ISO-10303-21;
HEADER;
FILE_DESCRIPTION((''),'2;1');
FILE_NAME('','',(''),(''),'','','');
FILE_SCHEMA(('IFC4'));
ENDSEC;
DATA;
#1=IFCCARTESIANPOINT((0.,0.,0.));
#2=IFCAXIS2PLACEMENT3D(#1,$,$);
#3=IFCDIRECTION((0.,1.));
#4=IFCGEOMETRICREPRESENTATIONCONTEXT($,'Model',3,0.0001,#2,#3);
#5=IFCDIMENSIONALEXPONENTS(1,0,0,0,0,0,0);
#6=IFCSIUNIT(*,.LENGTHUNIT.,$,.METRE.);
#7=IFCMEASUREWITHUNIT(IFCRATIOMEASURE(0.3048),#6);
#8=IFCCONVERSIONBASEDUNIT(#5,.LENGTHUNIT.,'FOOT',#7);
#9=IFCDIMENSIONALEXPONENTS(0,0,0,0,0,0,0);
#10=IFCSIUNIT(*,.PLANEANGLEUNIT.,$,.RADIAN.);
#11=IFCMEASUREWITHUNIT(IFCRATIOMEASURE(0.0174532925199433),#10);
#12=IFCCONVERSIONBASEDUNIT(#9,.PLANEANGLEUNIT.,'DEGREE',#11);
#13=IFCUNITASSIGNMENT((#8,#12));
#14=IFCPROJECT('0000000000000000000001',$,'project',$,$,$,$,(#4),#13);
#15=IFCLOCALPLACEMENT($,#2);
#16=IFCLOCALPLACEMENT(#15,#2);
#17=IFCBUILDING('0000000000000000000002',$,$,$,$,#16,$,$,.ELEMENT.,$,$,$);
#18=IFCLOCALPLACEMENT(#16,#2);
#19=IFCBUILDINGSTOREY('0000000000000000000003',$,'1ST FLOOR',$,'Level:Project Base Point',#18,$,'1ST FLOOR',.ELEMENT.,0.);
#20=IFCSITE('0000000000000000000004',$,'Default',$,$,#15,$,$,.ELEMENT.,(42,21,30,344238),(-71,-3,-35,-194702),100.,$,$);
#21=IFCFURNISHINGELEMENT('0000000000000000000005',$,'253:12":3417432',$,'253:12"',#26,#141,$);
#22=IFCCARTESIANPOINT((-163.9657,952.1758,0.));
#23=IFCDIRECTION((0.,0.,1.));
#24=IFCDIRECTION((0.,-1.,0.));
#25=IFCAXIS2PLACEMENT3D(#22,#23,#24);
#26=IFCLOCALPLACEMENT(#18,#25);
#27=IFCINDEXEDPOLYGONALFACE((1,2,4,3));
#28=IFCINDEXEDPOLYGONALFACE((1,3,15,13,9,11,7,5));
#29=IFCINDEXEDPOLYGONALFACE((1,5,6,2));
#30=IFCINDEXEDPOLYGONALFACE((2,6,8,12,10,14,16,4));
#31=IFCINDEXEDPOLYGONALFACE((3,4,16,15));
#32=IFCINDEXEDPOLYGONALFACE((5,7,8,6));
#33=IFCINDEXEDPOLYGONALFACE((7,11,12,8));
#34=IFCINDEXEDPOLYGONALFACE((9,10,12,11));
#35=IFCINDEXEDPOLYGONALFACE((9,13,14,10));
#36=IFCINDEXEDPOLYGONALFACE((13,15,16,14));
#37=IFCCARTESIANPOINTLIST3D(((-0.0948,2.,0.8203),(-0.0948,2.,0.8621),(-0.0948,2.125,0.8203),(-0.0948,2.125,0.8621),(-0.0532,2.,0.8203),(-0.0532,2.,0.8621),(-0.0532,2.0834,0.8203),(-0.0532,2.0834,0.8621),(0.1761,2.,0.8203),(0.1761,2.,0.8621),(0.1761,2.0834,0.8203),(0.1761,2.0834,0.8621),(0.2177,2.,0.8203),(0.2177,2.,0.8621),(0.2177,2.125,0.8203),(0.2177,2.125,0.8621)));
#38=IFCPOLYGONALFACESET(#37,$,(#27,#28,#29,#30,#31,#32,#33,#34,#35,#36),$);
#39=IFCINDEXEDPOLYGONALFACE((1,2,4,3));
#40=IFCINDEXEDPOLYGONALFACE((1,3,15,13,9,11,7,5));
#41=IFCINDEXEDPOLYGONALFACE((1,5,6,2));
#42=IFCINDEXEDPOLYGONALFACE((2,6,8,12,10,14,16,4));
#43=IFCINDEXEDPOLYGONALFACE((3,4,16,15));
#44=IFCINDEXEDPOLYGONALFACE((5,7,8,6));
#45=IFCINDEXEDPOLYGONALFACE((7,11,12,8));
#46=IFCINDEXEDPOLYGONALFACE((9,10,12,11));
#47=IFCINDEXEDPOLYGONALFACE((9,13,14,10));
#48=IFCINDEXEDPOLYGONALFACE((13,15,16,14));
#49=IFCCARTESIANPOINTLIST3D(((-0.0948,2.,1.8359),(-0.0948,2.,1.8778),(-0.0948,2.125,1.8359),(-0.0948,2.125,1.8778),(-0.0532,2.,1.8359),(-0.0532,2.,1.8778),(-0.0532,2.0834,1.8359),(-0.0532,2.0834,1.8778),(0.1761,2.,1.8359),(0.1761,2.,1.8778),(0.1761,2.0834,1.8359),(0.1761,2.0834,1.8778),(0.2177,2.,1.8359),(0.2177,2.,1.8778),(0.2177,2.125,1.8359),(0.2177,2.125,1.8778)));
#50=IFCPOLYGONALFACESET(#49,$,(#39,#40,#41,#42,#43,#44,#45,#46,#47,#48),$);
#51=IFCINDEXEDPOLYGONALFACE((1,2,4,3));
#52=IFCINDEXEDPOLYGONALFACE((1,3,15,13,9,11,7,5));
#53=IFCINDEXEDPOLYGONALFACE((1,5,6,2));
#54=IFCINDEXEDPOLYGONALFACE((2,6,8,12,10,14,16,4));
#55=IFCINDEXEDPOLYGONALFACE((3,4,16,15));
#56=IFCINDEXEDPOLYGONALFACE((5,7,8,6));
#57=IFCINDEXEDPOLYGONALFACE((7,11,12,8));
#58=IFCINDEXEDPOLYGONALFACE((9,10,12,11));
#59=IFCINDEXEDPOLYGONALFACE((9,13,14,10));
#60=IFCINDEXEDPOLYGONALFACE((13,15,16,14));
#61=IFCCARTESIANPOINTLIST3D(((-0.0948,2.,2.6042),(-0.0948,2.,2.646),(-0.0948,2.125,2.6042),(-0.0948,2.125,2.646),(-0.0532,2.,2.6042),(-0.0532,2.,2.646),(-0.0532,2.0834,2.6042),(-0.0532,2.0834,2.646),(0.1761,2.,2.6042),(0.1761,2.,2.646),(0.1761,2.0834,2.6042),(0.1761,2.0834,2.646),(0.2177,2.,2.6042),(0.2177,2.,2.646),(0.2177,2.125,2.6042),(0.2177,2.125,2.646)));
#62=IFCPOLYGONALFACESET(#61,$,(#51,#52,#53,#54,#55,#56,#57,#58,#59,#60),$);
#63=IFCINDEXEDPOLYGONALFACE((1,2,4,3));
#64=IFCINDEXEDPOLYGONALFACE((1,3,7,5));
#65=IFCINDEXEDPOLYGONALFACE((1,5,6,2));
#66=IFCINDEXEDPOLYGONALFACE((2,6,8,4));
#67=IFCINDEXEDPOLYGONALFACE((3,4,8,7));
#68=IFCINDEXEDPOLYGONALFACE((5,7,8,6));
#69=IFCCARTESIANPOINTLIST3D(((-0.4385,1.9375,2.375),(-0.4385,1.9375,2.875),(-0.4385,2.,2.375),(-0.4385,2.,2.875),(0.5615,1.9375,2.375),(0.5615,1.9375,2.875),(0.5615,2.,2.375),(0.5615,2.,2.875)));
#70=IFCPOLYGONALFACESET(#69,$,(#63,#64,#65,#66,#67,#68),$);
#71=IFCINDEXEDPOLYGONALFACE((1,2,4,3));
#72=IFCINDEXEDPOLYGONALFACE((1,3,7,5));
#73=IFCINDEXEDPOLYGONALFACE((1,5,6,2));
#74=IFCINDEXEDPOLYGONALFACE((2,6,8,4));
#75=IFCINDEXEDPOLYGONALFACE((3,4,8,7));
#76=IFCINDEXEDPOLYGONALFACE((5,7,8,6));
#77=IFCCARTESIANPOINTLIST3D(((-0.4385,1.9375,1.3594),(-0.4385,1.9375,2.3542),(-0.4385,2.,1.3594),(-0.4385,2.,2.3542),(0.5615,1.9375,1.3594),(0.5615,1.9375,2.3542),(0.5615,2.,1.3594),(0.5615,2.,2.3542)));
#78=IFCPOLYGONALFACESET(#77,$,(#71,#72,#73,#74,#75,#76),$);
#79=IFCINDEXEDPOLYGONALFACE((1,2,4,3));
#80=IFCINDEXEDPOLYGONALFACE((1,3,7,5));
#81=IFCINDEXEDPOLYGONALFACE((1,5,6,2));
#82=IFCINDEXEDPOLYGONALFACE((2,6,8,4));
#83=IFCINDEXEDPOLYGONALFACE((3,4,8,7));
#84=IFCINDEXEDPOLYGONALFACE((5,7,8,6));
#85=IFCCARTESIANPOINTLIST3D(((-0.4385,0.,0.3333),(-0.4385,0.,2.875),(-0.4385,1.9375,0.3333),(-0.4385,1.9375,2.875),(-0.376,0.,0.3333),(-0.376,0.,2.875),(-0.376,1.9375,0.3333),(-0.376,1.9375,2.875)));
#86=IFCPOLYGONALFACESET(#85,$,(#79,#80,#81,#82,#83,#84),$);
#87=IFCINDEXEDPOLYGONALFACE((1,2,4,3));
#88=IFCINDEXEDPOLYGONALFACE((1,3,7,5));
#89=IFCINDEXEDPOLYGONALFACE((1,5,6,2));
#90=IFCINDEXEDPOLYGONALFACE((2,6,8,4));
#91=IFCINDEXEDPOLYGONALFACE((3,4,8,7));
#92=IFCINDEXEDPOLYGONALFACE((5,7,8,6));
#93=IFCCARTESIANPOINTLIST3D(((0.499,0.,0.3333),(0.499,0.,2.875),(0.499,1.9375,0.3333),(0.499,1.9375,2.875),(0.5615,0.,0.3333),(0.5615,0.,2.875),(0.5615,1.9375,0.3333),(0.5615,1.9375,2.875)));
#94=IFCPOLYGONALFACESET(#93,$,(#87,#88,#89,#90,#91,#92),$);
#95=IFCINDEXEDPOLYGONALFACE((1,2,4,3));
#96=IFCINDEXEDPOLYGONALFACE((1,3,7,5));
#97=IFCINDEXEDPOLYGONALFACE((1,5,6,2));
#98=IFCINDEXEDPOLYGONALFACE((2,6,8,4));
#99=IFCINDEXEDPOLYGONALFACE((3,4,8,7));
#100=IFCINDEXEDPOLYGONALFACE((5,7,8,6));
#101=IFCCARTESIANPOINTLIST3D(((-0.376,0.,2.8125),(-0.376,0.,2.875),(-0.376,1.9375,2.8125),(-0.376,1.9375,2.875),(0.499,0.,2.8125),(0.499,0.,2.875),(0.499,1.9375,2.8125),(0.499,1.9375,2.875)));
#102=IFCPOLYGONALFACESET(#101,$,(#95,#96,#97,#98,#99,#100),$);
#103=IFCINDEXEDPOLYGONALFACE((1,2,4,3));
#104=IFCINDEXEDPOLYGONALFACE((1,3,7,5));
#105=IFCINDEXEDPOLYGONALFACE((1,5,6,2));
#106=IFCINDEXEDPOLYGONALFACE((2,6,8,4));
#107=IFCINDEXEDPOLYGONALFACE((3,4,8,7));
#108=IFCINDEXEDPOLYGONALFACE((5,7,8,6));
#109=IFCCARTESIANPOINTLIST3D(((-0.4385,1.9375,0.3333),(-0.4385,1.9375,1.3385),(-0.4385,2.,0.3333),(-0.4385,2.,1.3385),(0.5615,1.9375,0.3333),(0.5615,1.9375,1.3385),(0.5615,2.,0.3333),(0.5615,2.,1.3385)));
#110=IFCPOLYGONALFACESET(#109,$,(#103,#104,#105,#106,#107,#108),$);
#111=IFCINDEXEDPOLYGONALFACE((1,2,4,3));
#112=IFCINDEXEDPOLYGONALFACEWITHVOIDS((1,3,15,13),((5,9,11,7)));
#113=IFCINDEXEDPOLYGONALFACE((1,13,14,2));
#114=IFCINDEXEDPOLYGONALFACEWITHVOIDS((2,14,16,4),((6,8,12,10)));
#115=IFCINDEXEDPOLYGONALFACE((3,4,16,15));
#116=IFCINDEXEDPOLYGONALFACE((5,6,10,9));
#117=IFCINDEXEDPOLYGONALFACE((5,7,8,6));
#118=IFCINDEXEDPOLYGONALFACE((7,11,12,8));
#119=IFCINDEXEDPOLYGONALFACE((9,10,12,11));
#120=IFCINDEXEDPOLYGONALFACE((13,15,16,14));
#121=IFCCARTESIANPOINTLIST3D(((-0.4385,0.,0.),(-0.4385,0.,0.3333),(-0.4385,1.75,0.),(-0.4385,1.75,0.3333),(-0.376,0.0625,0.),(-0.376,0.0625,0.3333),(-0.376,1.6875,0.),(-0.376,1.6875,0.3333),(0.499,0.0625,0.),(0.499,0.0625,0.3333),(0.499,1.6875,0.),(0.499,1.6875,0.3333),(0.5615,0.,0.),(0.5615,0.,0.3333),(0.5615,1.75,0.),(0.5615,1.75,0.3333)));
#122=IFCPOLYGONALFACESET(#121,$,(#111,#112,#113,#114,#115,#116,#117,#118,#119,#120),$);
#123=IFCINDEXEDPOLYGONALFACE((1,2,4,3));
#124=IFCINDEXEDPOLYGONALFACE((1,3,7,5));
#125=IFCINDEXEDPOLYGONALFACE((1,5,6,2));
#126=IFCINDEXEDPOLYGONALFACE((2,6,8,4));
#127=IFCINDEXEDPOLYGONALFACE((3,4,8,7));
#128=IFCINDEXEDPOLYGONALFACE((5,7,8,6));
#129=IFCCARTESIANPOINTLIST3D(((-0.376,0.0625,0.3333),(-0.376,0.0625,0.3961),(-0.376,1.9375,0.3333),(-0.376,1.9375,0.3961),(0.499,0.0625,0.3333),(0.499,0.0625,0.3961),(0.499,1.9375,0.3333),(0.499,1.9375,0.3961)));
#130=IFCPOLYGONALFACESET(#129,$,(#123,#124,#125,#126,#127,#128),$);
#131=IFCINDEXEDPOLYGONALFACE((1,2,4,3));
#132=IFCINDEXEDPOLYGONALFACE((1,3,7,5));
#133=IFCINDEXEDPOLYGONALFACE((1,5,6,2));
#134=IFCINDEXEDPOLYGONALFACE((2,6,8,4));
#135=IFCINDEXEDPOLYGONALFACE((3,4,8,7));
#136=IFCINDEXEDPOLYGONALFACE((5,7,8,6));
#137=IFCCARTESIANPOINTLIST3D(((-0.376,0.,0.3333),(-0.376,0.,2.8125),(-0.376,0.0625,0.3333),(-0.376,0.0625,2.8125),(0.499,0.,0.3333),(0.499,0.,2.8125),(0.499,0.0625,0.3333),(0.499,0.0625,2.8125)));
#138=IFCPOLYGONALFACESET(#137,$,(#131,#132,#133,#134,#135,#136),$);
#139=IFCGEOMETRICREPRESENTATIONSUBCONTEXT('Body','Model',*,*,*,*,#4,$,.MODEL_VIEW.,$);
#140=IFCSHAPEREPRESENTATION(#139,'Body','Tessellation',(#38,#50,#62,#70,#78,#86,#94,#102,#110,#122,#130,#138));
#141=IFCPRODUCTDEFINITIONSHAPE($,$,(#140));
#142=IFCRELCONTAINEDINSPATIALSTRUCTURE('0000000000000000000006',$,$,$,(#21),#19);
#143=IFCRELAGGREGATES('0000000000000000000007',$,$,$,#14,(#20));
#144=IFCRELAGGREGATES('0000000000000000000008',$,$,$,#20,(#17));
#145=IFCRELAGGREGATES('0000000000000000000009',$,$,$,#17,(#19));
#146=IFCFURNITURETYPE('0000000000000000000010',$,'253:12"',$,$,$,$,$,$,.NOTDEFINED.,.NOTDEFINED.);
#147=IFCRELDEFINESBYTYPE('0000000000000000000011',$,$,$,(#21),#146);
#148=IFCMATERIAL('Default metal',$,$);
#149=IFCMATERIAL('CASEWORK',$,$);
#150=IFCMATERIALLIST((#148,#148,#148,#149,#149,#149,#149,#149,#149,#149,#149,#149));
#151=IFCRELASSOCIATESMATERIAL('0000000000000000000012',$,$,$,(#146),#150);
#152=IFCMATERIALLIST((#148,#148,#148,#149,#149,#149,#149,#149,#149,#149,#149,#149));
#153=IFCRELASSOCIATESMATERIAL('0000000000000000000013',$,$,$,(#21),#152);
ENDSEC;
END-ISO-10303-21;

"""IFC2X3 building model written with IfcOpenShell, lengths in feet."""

from ifc_helpers import new_model, entity, si_unit, converted_unit, direction, frame, frame_2d, origin, origin_2d_with_axis, place, context, subcontext, project, spatial, polyline, rectangle, outline, extrude, source, transform, mapped, material, material_list, type_object, type_shapes, element, save


model = new_model("IFC2X3")

# Units and contexts
model_context = context("Model", 3, precision=0.0001, world=origin(), true_north=direction((0.0, 1.0)))
body_context = subcontext(model_context, "Body", "Model", "MODEL_VIEW")
ifc_project = project(units=[converted_unit("LENGTHUNIT", "FOOT", entity("IfcRatioMeasure", 0.3048), si_unit("LENGTHUNIT", "METRE"), dimensions=[1, 0, 0, 0, 0, 0, 0]), converted_unit("PLANEANGLEUNIT", "DEGREE", entity("IfcRatioMeasure", 0.0174532925199433), si_unit("PLANEANGLEUNIT", "RADIAN"), dimensions=[0, 0, 0, 0, 0, 0, 0])], contexts=[model_context])

# Site, building, storey
site_placement = place(None, origin())
site = spatial("IfcSite", under=ifc_project, at=site_placement, Name="Default", CompositionType="ELEMENT", RefLatitude=(42, 21, 30, 344238), RefLongitude=(-71, -3, -35, -194702), RefElevation=100.0)
building_placement = place(site_placement, origin())
building = spatial("IfcBuilding", under=site, at=building_placement, CompositionType="ELEMENT")
storey_placement = place(building_placement, origin())
storey = spatial("IfcBuildingStorey", under=building, at=storey_placement, Name="1ST FLOOR", ObjectType="Level:Project Base Point", LongName="1ST FLOOR", CompositionType="ELEMENT", Elevation=0.0)

# Shared definitions
ifc_material_1 = material(Name="CASEWORK")

# Furnishing element
ifc_material_2 = material(Name="Default metal")
ifc_material_list_1 = material_list([ifc_material_2, ifc_material_2, ifc_material_2, ifc_material_1, ifc_material_1, ifc_material_1, ifc_material_1, ifc_material_1, ifc_material_1, ifc_material_1, ifc_material_1, ifc_material_1])
ifc_material_list_2 = material_list([ifc_material_2, ifc_material_2, ifc_material_2, ifc_material_1, ifc_material_1, ifc_material_1, ifc_material_1, ifc_material_1, ifc_material_1, ifc_material_1, ifc_material_1, ifc_material_1])
furniture_type_1 = type_object("IfcFurnitureType", Name="253:12\"", material=ifc_material_list_2)
shared_shape_1 = source(origin(), body_context, "Body", "SweptSolid", [
    extrude(outline(polyline([(-0.1562, -0.0521), (-0.1146, -0.0521), (-0.1146, 0.0313), (0.1146, 0.0313), (0.1146, -0.0521), (0.1562, -0.0521), (0.1562, 0.0729), (-0.1562, 0.0729), (-0.1562, -0.0521)])), frame((0.0615, 2.0521, 0.8203)), (0.0, 0.0, 1.0), 0.0418),
    extrude(outline(polyline([(-0.1562, -0.0521), (-0.1146, -0.0521), (-0.1146, 0.0313), (0.1146, 0.0313), (0.1146, -0.0521), (0.1562, -0.0521), (0.1562, 0.0729), (-0.1562, 0.0729), (-0.1562, -0.0521)])), frame((0.0615, 2.0521, 1.8359)), (0.0, 0.0, 1.0), 0.0418),
    extrude(outline(polyline([(-0.1562, -0.0521), (-0.1146, -0.0521), (-0.1146, 0.0313), (0.1146, 0.0313), (0.1146, -0.0521), (0.1562, -0.0521), (0.1562, 0.0729), (-0.1562, 0.0729), (-0.1562, -0.0521)])), frame((0.0615, 2.0521, 2.6042)), (0.0, 0.0, 1.0), 0.0418),
    extrude(rectangle(XDim=1.0, YDim=0.0625, at=frame_2d((0.0, 0.0), x_axis=(1.0, 0.0))), frame((0.0615, 1.9688, 2.375), z_axis=(0.0, 0.0, 1.0), x_axis=(-1.0, 0.0, 0.0)), (0.0, 0.0, 1.0), 0.5),
    extrude(rectangle(XDim=1.0, YDim=0.0625, at=frame_2d((0.0, 0.0), x_axis=(1.0, 0.0))), frame((0.0615, 1.9688, 1.3594), z_axis=(0.0, 0.0, 1.0), x_axis=(-1.0, 0.0, 0.0)), (0.0, 0.0, 1.0), 0.9948),
    extrude(rectangle(XDim=1.9375, YDim=0.0625, at=frame_2d((0.0, 0.0), x_axis=(1.0, 0.0))), frame((-0.4073, 0.9687, 0.3333), z_axis=(0.0, 0.0, 1.0), x_axis=(0.0, -1.0, 0.0)), (0.0, 0.0, 1.0), 2.5417),
    extrude(rectangle(XDim=1.9375, YDim=0.0625, at=frame_2d((0.0, 0.0), x_axis=(1.0, 0.0))), frame((0.5302, 0.9687, 0.3333), z_axis=(0.0, 0.0, 1.0), x_axis=(0.0, -1.0, 0.0)), (0.0, 0.0, 1.0), 2.5417),
    extrude(rectangle(XDim=1.9375, YDim=0.875, at=origin_2d_with_axis()), frame((0.0615, 0.9688, 2.8125), z_axis=(0.0, 0.0, 1.0), x_axis=(0.0, 1.0, 0.0)), (0.0, 0.0, 1.0), 0.0625),
    extrude(rectangle(XDim=1.0, YDim=0.0625, at=frame_2d((0.0, 0.0), x_axis=(1.0, 0.0))), frame((0.0615, 1.9688, 0.3333), z_axis=(0.0, 0.0, 1.0), x_axis=(-1.0, 0.0, 0.0)), (0.0, 0.0, 1.0), 1.0052),
    extrude(outline(polyline([(-0.875, -0.5), (0.875, -0.5), (0.875, 0.5), (-0.875, 0.5), (-0.875, -0.5)]), holes=[polyline([(-0.8125, -0.4375), (-0.8125, 0.4375), (0.8125, 0.4375), (0.8125, -0.4375), (-0.8125, -0.4375)])]), frame((0.0615, 0.875, 0.0), z_axis=(0.0, 0.0, 1.0), x_axis=(0.0, -1.0, 0.0)), (0.0, 0.0, 1.0), 0.3333),
    extrude(rectangle(XDim=1.875, YDim=0.875, at=origin_2d_with_axis()), frame((0.0615, 1.0, 0.3333), z_axis=(0.0, 0.0, 1.0), x_axis=(0.0, 1.0, 0.0)), (0.0, 0.0, 1.0), 0.0627),
    extrude(rectangle(XDim=0.875, YDim=0.0625, at=origin_2d_with_axis()), frame((0.0615, 0.0312, 0.3333), z_axis=(0.0, 0.0, 1.0), x_axis=(-1.0, 0.0, 0.0)), (0.0, 0.0, 1.0), 2.4792),
])
type_shapes(furniture_type_1, [shared_shape_1])
furnishing_1_placement = place(storey_placement, frame((-163.9657, 952.1758, 0.0), z_axis=(0.0, 0.0, 1.0), x_axis=(0.0, -1.0, 0.0)))
element("IfcFurnishingElement", 1, at=furnishing_1_placement, inside=storey, type_object=furniture_type_1, material=ifc_material_list_1, Name="253:12\":3417432", ObjectType="253:12\"", context=body_context, shape_type="MappedRepresentation", body=[
    mapped(shared_shape_1, transform((0.0, 0.0, 0.0), scale=1.0)),
])

save(model, "model.ifc")
